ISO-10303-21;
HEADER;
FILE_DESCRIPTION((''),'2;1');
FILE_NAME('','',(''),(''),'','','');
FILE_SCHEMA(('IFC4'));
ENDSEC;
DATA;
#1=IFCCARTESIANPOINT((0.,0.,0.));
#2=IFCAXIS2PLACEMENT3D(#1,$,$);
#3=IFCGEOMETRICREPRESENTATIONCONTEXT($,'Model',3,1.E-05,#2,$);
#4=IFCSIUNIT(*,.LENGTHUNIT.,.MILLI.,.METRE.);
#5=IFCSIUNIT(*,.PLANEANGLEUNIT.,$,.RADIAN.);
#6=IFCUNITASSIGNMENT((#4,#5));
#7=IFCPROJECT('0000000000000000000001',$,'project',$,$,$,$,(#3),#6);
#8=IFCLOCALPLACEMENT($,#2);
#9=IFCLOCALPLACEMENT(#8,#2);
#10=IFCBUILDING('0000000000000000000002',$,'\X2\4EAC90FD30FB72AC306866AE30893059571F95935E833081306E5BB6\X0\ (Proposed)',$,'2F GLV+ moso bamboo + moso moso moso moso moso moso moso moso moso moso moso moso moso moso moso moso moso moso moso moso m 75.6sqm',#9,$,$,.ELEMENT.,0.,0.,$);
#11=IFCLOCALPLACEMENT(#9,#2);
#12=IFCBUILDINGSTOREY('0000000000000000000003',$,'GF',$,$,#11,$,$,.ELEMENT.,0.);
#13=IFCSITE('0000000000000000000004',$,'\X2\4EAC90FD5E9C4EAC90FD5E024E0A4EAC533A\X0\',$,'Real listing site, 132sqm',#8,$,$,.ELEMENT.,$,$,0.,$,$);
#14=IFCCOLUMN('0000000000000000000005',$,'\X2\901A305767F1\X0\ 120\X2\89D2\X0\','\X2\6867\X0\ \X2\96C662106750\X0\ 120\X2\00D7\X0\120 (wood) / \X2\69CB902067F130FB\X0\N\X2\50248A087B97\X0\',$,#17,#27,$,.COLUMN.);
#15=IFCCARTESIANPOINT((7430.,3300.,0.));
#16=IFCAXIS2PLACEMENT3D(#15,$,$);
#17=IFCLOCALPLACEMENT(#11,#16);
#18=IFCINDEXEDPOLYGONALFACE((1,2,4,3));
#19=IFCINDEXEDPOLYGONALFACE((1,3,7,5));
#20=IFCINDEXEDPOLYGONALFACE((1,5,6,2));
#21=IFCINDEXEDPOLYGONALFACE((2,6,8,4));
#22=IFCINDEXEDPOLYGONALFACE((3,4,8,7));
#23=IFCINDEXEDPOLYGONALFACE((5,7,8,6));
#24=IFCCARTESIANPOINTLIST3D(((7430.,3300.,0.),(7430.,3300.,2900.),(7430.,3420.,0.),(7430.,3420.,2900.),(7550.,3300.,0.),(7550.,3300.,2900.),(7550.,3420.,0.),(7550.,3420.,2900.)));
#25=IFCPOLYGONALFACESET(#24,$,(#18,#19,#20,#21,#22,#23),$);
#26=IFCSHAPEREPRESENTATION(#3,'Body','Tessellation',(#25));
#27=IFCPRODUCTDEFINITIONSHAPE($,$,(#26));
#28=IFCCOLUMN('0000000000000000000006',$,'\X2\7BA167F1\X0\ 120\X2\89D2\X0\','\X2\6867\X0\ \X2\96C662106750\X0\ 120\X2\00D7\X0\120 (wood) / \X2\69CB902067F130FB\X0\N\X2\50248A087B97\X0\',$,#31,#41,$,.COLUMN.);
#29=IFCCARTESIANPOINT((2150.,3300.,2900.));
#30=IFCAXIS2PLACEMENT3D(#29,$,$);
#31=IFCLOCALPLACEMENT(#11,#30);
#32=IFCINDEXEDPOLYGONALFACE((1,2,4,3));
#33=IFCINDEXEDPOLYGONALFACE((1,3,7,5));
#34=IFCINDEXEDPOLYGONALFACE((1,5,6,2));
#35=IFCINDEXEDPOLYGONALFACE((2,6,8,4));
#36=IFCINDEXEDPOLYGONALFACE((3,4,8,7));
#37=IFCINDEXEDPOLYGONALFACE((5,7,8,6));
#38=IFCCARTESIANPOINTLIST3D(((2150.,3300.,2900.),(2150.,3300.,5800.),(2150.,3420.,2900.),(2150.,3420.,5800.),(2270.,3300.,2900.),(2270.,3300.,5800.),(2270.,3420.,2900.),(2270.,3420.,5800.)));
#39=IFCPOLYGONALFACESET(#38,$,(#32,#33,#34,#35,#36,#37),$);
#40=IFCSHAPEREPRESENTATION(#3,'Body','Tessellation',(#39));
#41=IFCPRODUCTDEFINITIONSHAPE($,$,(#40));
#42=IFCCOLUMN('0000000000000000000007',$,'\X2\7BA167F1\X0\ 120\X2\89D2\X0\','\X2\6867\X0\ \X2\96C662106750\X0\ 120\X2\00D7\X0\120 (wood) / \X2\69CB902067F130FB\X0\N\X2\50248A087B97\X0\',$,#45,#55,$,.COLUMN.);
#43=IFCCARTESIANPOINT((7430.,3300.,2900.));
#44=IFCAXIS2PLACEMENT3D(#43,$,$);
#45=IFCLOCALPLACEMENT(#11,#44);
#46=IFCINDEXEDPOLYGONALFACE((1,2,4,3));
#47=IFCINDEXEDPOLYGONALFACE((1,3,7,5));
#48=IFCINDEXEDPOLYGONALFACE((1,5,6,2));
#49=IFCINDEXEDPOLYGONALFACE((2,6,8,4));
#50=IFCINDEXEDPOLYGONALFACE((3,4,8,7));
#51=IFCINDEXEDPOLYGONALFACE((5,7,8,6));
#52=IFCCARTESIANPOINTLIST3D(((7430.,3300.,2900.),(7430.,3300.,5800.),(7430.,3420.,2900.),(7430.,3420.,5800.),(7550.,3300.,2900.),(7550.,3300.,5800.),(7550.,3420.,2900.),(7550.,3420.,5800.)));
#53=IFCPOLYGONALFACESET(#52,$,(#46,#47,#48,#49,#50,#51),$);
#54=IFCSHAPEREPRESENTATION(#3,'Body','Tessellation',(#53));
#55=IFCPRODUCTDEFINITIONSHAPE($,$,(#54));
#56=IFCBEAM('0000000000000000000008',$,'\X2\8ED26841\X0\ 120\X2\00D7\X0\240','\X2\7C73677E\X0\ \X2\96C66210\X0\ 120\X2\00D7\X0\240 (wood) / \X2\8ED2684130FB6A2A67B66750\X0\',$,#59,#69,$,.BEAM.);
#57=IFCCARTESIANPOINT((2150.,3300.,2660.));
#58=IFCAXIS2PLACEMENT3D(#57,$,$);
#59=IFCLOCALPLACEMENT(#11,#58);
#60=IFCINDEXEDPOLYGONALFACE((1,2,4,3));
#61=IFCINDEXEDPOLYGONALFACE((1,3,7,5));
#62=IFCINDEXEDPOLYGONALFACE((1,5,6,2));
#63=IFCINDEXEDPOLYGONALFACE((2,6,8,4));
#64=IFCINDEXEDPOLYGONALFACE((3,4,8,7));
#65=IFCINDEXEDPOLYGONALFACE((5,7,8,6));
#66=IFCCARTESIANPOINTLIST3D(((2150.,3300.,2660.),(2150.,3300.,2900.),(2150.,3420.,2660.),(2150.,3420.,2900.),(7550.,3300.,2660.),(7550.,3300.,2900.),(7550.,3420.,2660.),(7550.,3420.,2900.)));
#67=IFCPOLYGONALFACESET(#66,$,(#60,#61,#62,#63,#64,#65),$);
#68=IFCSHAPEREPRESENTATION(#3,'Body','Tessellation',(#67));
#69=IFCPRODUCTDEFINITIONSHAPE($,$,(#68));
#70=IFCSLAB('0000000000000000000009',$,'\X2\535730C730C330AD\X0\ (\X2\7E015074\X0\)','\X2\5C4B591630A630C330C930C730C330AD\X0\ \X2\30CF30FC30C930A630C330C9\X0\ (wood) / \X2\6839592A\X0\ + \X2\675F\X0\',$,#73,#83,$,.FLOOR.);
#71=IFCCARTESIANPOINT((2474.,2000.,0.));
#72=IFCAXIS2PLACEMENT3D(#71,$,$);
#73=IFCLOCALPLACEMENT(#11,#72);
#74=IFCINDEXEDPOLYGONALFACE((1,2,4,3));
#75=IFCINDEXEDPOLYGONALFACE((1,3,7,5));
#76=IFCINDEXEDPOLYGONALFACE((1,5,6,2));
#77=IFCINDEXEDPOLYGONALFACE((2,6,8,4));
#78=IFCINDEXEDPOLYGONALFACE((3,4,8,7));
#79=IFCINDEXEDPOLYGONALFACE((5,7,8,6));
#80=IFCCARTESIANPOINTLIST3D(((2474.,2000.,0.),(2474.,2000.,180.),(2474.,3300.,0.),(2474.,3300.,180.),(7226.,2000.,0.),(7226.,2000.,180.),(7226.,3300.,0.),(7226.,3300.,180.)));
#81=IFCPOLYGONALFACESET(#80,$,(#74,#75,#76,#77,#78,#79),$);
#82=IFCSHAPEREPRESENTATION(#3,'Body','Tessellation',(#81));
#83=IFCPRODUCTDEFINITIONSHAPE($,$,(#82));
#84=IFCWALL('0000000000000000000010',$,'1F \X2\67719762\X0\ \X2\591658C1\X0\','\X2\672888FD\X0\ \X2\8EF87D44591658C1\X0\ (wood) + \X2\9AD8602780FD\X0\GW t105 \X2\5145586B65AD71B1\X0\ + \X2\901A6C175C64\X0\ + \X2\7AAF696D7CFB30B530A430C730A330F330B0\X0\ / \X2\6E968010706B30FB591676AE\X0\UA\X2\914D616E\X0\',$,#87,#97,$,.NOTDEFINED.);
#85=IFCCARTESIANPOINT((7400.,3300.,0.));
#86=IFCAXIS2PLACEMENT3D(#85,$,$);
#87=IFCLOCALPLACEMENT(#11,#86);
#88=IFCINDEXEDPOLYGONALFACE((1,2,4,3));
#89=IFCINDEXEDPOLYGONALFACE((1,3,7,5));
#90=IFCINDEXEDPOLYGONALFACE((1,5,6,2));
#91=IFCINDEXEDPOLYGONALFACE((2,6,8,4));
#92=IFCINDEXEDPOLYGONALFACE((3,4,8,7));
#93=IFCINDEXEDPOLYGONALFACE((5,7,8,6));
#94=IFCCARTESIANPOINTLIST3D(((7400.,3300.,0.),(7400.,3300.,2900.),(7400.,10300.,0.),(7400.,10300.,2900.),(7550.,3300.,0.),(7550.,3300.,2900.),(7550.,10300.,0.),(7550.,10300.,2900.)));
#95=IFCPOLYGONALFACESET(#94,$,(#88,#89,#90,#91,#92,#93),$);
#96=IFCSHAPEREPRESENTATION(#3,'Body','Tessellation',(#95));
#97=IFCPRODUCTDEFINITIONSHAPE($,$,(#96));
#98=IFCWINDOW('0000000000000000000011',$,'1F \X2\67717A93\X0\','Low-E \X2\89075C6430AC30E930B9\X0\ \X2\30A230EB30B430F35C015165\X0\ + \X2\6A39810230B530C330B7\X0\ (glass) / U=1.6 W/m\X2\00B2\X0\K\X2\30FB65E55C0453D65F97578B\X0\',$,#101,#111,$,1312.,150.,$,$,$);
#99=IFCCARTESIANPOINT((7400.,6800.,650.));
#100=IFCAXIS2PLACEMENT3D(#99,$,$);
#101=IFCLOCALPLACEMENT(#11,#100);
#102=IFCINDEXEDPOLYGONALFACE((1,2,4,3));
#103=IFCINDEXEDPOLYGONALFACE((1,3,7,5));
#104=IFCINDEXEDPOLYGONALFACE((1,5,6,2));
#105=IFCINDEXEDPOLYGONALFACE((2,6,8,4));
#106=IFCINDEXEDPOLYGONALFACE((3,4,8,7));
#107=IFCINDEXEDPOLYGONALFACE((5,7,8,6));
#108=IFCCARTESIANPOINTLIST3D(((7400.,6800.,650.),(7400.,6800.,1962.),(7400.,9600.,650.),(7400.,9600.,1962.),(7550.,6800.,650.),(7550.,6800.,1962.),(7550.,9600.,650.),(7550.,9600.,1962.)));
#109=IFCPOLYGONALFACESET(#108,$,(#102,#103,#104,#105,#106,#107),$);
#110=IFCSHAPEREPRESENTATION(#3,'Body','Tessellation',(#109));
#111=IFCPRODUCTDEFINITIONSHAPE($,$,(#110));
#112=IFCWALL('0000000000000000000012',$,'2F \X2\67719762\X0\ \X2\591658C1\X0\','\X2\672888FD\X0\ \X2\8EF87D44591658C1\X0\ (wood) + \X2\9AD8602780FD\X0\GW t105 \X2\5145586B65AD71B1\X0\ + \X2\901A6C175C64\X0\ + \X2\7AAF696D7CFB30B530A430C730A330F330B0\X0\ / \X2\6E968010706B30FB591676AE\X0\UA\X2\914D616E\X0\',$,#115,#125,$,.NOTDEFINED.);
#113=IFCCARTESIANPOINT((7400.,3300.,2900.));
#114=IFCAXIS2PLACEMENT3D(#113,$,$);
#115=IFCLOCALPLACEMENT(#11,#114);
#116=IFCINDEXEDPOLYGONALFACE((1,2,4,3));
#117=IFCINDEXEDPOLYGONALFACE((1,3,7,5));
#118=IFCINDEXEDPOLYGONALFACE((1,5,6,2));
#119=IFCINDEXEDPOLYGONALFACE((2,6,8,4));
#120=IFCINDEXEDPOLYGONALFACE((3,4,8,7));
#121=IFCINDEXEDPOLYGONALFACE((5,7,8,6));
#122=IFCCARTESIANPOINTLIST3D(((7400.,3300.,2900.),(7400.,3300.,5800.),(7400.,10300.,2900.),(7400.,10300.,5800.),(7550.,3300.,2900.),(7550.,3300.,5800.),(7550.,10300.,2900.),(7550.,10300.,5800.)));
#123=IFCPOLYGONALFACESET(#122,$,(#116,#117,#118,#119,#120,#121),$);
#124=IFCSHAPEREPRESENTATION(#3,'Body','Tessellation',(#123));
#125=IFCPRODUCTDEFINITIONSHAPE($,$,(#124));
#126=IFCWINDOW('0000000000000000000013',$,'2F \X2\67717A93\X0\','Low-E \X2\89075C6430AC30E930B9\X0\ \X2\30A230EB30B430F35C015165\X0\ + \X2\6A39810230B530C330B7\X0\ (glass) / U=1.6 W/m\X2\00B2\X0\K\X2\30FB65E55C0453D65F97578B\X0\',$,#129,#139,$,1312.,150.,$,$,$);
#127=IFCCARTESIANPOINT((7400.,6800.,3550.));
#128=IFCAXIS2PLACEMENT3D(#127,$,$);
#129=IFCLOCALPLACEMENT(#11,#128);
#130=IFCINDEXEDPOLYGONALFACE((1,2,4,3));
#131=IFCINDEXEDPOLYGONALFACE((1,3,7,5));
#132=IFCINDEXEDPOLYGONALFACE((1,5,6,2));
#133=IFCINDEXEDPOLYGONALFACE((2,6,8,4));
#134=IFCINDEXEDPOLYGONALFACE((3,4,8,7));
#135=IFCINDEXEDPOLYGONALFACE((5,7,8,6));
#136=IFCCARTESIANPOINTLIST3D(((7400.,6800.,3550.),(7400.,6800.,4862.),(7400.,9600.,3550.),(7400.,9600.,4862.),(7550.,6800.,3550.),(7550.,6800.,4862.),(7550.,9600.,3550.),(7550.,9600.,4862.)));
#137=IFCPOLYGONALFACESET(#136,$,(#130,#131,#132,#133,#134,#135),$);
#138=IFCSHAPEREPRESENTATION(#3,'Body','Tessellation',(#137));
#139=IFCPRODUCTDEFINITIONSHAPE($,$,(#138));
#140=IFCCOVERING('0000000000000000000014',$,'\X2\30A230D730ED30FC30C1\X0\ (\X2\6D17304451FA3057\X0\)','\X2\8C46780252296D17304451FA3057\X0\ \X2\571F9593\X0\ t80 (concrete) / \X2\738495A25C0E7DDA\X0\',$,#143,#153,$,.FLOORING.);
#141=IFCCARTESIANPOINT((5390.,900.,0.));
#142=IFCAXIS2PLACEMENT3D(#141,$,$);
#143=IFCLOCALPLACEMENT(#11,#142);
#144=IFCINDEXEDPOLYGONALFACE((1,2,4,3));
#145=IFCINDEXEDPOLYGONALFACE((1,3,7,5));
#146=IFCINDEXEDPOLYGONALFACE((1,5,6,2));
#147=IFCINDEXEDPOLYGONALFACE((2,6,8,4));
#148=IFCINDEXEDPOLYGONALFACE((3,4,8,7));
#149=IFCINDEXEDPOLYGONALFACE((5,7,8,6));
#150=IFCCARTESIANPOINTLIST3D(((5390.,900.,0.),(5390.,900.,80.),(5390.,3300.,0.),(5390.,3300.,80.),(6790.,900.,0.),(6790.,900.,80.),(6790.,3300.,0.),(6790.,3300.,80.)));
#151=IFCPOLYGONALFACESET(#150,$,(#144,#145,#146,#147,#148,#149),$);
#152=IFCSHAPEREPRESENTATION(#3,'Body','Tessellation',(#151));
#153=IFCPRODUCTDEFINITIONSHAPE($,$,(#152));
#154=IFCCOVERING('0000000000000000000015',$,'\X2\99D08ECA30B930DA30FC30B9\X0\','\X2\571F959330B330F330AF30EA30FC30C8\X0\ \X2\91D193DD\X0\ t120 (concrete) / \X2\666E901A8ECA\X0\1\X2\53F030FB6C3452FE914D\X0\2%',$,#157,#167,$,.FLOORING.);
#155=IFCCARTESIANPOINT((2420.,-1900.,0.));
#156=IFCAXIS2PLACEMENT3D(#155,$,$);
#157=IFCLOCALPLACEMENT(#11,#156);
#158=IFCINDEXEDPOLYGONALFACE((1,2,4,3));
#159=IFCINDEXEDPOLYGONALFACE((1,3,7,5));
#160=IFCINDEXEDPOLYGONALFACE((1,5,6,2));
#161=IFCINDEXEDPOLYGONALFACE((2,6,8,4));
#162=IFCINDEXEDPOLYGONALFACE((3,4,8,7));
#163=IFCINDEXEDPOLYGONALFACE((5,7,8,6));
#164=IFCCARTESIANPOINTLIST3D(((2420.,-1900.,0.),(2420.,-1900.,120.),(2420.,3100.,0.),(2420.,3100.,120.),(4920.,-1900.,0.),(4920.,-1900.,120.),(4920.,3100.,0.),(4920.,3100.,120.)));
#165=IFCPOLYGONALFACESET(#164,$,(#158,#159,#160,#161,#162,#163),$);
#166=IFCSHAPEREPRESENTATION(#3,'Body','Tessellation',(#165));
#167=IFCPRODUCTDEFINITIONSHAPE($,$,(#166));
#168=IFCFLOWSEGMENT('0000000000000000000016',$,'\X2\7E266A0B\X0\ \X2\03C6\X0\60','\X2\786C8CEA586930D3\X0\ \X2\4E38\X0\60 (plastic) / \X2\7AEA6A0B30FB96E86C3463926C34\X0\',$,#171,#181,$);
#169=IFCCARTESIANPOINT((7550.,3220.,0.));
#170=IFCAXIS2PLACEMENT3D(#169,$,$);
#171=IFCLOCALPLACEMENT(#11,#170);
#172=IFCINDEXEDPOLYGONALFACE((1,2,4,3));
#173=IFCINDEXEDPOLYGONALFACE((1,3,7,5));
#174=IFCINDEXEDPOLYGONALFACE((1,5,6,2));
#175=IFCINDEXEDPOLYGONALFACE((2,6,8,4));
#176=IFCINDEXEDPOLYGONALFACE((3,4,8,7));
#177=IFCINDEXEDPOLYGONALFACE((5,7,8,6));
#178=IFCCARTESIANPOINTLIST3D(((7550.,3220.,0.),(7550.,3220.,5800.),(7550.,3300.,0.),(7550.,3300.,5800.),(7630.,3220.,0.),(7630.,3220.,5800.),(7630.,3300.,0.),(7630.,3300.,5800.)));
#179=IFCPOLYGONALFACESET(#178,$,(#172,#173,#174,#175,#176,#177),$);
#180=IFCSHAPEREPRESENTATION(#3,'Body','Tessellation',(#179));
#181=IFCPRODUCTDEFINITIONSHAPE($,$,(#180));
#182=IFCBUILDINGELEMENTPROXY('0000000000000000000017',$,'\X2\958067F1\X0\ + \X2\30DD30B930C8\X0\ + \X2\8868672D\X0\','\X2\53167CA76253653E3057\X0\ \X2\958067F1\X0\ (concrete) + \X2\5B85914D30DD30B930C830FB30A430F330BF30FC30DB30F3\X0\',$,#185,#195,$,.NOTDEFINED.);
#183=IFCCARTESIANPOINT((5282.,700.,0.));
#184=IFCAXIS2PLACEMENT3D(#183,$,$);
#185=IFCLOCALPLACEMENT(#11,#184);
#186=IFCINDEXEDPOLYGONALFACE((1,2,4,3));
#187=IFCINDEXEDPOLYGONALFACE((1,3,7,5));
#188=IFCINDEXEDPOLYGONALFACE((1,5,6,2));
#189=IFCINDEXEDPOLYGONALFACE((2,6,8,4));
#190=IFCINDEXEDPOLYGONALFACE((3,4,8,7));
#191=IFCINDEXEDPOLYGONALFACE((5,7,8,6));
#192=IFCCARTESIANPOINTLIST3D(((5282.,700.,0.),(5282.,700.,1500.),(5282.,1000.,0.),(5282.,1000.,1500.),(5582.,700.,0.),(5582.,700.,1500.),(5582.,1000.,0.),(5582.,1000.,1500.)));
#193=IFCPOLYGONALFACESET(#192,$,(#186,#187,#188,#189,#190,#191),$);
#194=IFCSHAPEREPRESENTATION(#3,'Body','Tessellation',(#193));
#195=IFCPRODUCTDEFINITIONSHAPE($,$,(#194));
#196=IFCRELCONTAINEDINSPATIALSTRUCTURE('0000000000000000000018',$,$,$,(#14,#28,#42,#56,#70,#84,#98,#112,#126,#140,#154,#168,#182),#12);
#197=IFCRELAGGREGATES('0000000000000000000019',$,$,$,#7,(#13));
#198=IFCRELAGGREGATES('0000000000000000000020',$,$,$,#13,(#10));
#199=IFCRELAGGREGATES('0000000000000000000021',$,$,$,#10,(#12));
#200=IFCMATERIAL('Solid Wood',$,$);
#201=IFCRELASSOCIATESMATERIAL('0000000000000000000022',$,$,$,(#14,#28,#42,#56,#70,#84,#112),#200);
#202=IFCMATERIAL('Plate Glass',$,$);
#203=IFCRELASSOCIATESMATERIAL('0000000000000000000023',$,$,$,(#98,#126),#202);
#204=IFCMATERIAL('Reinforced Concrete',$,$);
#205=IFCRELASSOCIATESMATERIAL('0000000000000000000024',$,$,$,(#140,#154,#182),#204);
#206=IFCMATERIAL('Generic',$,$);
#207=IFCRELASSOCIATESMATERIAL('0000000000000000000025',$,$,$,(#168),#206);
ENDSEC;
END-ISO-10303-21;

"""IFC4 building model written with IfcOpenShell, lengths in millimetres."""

from ifc_helpers import new_model, si_unit, frame, frame_2d, origin, place, context, project, spatial, rectangle, extrude, material, element, fill, save


model = new_model("IFC4")

# Units and contexts
model_context = context("Model", 3, precision=1e-05, world=origin())
ifc_project = project(units=[si_unit("LENGTHUNIT", "METRE", prefix="MILLI"), si_unit("PLANEANGLEUNIT", "RADIAN")], contexts=[model_context])

# Site, building, storey
site_placement = place(None, origin())
site = spatial("IfcSite", under=ifc_project, at=site_placement, Name="京都府京都市上京区", ObjectType="Real listing site, 132sqm", CompositionType="ELEMENT", RefElevation=0.0)
building_placement = place(site_placement, origin())
building = spatial("IfcBuilding", under=site, at=building_placement, Name="京都・犬と暮らす土間広めの家 (Proposed)", ObjectType="2F GLV+ moso bamboo + moso moso moso moso moso moso moso moso moso moso moso moso moso moso moso moso moso moso moso moso m 75.6sqm", CompositionType="ELEMENT", ElevationOfRefHeight=0.0, ElevationOfTerrain=0.0)
storey_placement = place(building_placement, origin())
storey = spatial("IfcBuildingStorey", under=building, at=storey_placement, Name="GF", CompositionType="ELEMENT", Elevation=0.0)

# Columns
ifc_material_1 = material(Name="Solid Wood")
column_1_placement = place(storey_placement, frame((7430.0, 3300.0, 0.0)))
element("IfcColumn", 1, at=column_1_placement, inside=storey, material=ifc_material_1, Name="通し柱 120角", Description="桧 集成材 120×120 (wood) / 構造柱・N値計算", PredefinedType="COLUMN", context=model_context, shape_type="SweptSolid", body=[
    extrude(rectangle(XDim=120.0, YDim=120.0, at=frame_2d((60.0, 60.0))), frame((7430.0, 3300.0, 0.0)), (0.0, 0.0, 1.0), 2900.0),
])
column_2_placement = place(storey_placement, frame((2150.0, 3300.0, 2900.0)))
element("IfcColumn", 2, at=column_2_placement, inside=storey, material=ifc_material_1, Name="管柱 120角", Description="桧 集成材 120×120 (wood) / 構造柱・N値計算", PredefinedType="COLUMN", context=model_context, shape_type="SweptSolid", body=[
    extrude(rectangle(XDim=120.0, YDim=120.0, at=frame_2d((60.0, 60.0))), frame((2150.0, 3300.0, 2900.0)), (0.0, 0.0, 1.0), 2900.0),
])
column_3_placement = place(storey_placement, frame((7430.0, 3300.0, 2900.0)))
element("IfcColumn", 3, at=column_3_placement, inside=storey, material=ifc_material_1, Name="管柱 120角", Description="桧 集成材 120×120 (wood) / 構造柱・N値計算", PredefinedType="COLUMN", context=model_context, shape_type="SweptSolid", body=[
    extrude(rectangle(XDim=120.0, YDim=120.0, at=frame_2d((60.0, 60.0))), frame((7430.0, 3300.0, 2900.0)), (0.0, 0.0, 1.0), 2900.0),
])

# Beam
beam_1_placement = place(storey_placement, frame((2150.0, 3300.0, 2660.0)))
element("IfcBeam", 4, at=beam_1_placement, inside=storey, material=ifc_material_1, Name="軒桁 120×240", Description="米松 集成 120×240 (wood) / 軒桁・横架材", PredefinedType="BEAM", context=model_context, shape_type="SweptSolid", body=[
    extrude(rectangle(XDim=5400.0, YDim=120.0, at=frame_2d((2700.0, 60.0))), frame((2150.0, 3300.0, 2660.0)), (0.0, 0.0, 1.0), 240.0),
])

# Slab
slab_placement = place(storey_placement, frame((2474.0, 2000.0, 0.0)))
element("IfcSlab", 5, at=slab_placement, inside=storey, material=ifc_material_1, Name="南デッキ (縁側)", Description="屋外ウッドデッキ ハードウッド (wood) / 根太 + 束", PredefinedType="FLOOR", context=model_context, shape_type="SweptSolid", body=[
    extrude(rectangle(XDim=4752.0, YDim=1300.0, at=frame_2d((2376.0, 650.0))), frame((2474.0, 2000.0, 0.0)), (0.0, 0.0, 1.0), 180.0),
])

# Walls, openings, windows
wall_1_placement = place(storey_placement, frame((7400.0, 3300.0, 0.0)))
wall_1 = element("IfcWall", 6, at=wall_1_placement, inside=storey, material=ifc_material_1, Name="1F 東面 外壁", Description="木製 軸組外壁 (wood) + 高性能GW t105 充填断熱 + 通気層 + 窯業系サイディング / 準耐火・外皮UA配慮", PredefinedType="NOTDEFINED", context=model_context, shape_type="SweptSolid", body=[
    extrude(rectangle(XDim=150.0, YDim=7000.0, at=frame_2d((75.0, 3500.0))), frame((7400.0, 3300.0, 0.0)), (0.0, 0.0, 1.0), 2900.0),
])
opening_1_placement = place(storey_placement, frame((7400.0, 6800.0, 650.0)))
opening_1 = element("IfcOpeningElement", 7, at=opening_1_placement, cuts=wall_1, PredefinedType="NOTDEFINED", context=model_context, shape_type="SweptSolid", body=[
    extrude(rectangle(XDim=150.0, YDim=2800.0, at=frame_2d((75.0, 1400.0))), frame((7400.0, 6800.0, 650.0)), (0.0, 0.0, 1.0), 1312.0),
])
ifc_material_2 = material(Name="Plate Glass")
window_1_placement = place(storey_placement, frame((7400.0, 6800.0, 650.0)))
window_1 = element("IfcWindow", 8, at=window_1_placement, inside=storey, material=ifc_material_2, Name="1F 東窓", Description="Low-E 複層ガラス アルゴン封入 + 樹脂サッシ (glass) / U=1.6 W/m²K・日射取得型", OverallHeight=1312.0, OverallWidth=150.0, context=model_context, shape_type="SweptSolid", body=[
    extrude(rectangle(XDim=150.0, YDim=2800.0, at=frame_2d((75.0, 1400.0))), frame((7400.0, 6800.0, 650.0)), (0.0, 0.0, 1.0), 1312.0),
])
fill(opening_1, window_1)
wall_2_placement = place(storey_placement, frame((7400.0, 3300.0, 2900.0)))
wall_2 = element("IfcWall", 9, at=wall_2_placement, inside=storey, material=ifc_material_1, Name="2F 東面 外壁", Description="木製 軸組外壁 (wood) + 高性能GW t105 充填断熱 + 通気層 + 窯業系サイディング / 準耐火・外皮UA配慮", PredefinedType="NOTDEFINED", context=model_context, shape_type="SweptSolid", body=[
    extrude(rectangle(XDim=150.0, YDim=7000.0, at=frame_2d((75.0, 3500.0))), frame((7400.0, 3300.0, 2900.0)), (0.0, 0.0, 1.0), 2900.0),
])
opening_2_placement = place(storey_placement, frame((7400.0, 6800.0, 3550.0)))
opening_2 = element("IfcOpeningElement", 10, at=opening_2_placement, cuts=wall_2, PredefinedType="NOTDEFINED", context=model_context, shape_type="SweptSolid", body=[
    extrude(rectangle(XDim=150.0, YDim=2800.0, at=frame_2d((75.0, 1400.0))), frame((7400.0, 6800.0, 3550.0)), (0.0, 0.0, 1.0), 1312.0),
])
window_2_placement = place(storey_placement, frame((7400.0, 6800.0, 3550.0)))
window_2 = element("IfcWindow", 11, at=window_2_placement, inside=storey, material=ifc_material_2, Name="2F 東窓", Description="Low-E 複層ガラス アルゴン封入 + 樹脂サッシ (glass) / U=1.6 W/m²K・日射取得型", OverallHeight=1312.0, OverallWidth=150.0, context=model_context, shape_type="SweptSolid", body=[
    extrude(rectangle(XDim=150.0, YDim=2800.0, at=frame_2d((75.0, 1400.0))), frame((7400.0, 6800.0, 3550.0)), (0.0, 0.0, 1.0), 1312.0),
])
fill(opening_2, window_2)

# Coverings
ifc_material_3 = material(Name="Reinforced Concrete")
covering_1_placement = place(storey_placement, frame((5390.0, 900.0, 0.0)))
element("IfcCovering", 12, at=covering_1_placement, inside=storey, material=ifc_material_3, Name="アプローチ (洗い出し)", Description="豆砂利洗い出し 土間 t80 (concrete) / 玄関導線", PredefinedType="FLOORING", context=model_context, shape_type="SweptSolid", body=[
    extrude(rectangle(XDim=1400.0, YDim=2400.0, at=frame_2d((700.0, 1200.0))), frame((5390.0, 900.0, 0.0)), (0.0, 0.0, 1.0), 80.0),
])
covering_2_placement = place(storey_placement, frame((2420.0, -1900.0, 0.0)))
element("IfcCovering", 13, at=covering_2_placement, inside=storey, material=ifc_material_3, Name="駐車スペース", Description="土間コンクリート 金鏝 t120 (concrete) / 普通車1台・水勾配2%", PredefinedType="FLOORING", context=model_context, shape_type="SweptSolid", body=[
    extrude(rectangle(XDim=2500.0, YDim=5000.0, at=frame_2d((1250.0, 2500.0))), frame((2420.0, -1900.0, 0.0)), (0.0, 0.0, 1.0), 120.0),
])

# Flow segment
ifc_material_4 = material(Name="Generic")
flow_segment_placement = place(storey_placement, frame((7550.0, 3220.0, 0.0)))
element("IfcFlowSegment", 14, at=flow_segment_placement, inside=storey, material=ifc_material_4, Name="縦樋 φ60", Description="硬質塩ビ 丸60 (plastic) / 竪樋・雨水排水", context=model_context, shape_type="SweptSolid", body=[
    extrude(rectangle(XDim=80.0, YDim=80.0, at=frame_2d((40.0, 40.0))), frame((7550.0, 3220.0, 0.0)), (0.0, 0.0, 1.0), 5800.0),
])

# Building element proxy
proxy_placement = place(storey_placement, frame((5282.0, 700.0, 0.0)))
element("IfcBuildingElementProxy", 15, at=proxy_placement, inside=storey, material=ifc_material_3, Name="門柱 + ポスト + 表札", Description="化粧打放し 門柱 (concrete) + 宅配ポスト・インターホン", PredefinedType="NOTDEFINED", context=model_context, shape_type="SweptSolid", body=[
    extrude(rectangle(XDim=300.0, YDim=300.0, at=frame_2d((150.0, 150.0))), frame((5282.0, 700.0, 0.0)), (0.0, 0.0, 1.0), 1500.0),
])

save(model, "model.ifc")
